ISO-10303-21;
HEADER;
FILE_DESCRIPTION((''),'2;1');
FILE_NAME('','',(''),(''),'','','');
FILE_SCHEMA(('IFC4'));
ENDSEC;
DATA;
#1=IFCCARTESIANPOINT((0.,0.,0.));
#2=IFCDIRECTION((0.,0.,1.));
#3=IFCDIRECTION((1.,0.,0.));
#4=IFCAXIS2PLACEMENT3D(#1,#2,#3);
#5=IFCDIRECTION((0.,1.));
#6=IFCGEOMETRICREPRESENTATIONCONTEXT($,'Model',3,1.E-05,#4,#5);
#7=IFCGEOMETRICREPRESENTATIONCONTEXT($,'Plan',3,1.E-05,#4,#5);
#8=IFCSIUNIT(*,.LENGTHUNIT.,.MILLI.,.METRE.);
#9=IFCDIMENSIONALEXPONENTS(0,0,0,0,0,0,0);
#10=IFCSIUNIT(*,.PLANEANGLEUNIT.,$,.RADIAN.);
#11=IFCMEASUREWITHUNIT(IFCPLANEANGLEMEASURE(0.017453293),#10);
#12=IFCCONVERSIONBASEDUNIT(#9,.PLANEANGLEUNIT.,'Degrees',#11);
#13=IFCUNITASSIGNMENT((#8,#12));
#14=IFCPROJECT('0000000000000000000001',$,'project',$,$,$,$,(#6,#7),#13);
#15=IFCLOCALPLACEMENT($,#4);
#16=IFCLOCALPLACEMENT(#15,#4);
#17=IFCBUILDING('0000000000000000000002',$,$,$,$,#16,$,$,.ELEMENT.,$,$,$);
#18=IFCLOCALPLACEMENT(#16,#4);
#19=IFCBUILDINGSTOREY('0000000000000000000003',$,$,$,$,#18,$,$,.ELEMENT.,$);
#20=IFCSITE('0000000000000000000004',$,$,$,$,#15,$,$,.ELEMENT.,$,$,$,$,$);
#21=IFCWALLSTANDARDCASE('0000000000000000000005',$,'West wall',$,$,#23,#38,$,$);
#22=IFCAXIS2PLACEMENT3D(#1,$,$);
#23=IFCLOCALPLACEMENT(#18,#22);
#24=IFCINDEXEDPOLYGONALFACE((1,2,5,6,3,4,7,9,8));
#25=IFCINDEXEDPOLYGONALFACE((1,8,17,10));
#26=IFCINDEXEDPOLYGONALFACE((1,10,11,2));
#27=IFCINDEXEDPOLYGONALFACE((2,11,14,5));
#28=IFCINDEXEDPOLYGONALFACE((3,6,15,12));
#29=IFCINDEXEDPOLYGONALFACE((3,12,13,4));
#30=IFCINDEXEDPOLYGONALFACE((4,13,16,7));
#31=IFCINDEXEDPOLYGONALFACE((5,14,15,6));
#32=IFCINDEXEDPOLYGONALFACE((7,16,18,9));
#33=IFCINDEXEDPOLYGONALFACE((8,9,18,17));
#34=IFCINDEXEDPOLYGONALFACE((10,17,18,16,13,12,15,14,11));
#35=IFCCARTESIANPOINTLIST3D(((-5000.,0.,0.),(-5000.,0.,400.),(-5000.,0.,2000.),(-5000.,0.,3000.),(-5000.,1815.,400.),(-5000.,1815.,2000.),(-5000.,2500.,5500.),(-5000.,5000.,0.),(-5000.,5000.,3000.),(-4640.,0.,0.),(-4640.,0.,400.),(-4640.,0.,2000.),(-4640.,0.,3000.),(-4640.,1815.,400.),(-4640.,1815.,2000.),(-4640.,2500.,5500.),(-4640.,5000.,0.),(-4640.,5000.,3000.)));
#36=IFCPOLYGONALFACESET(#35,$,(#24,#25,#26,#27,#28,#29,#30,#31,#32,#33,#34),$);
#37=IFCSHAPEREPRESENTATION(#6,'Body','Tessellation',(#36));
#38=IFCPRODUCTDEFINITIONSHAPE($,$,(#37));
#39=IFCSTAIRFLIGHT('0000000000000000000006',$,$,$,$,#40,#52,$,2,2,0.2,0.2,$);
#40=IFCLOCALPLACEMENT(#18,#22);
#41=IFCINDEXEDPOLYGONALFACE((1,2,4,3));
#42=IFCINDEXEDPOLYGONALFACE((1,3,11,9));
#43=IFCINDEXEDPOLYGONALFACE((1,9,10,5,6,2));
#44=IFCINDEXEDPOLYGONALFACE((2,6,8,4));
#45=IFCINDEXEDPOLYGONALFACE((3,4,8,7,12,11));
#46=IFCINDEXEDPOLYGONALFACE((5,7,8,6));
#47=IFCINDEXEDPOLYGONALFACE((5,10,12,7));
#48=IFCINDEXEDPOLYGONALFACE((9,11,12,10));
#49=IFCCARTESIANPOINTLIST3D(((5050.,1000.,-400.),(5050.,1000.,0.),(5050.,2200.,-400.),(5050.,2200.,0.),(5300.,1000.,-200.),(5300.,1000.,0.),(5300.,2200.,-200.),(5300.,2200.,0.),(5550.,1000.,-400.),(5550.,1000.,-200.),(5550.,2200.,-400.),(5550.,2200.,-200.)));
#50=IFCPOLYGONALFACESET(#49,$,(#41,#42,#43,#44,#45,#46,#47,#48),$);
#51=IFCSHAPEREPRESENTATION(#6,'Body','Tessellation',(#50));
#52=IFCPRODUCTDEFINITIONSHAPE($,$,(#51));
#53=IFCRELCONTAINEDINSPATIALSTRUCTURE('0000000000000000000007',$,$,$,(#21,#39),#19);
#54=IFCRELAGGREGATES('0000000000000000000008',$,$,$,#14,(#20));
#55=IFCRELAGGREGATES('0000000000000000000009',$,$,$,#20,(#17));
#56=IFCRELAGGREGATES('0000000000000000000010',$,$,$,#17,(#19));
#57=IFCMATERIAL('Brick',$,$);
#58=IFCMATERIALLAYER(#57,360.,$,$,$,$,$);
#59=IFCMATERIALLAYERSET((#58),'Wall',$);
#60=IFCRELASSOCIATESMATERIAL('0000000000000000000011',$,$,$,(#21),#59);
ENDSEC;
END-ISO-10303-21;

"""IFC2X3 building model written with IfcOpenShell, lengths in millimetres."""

from ifc_helpers import new_model, entity, si_unit, converted_unit, direction, frame, origin_with_axes, place, context, project, spatial, polyline, outline, extrude, clip, halfspace, material, layer, layer_set, layer_usage, element, save


model = new_model("IFC2X3")

# Units and contexts
model_context = context("Model", 3, precision=1e-05, world=origin_with_axes(), true_north=direction((0.0, 1.0)))
plan_context = context("Plan", 3, precision=1e-05, world=origin_with_axes(), true_north=direction((0.0, 1.0)))
ifc_project = project(units=[si_unit("LENGTHUNIT", "METRE", prefix="MILLI"), converted_unit("PLANEANGLEUNIT", "Degrees", entity("IfcPlaneAngleMeasure", 0.017453293), si_unit("PLANEANGLEUNIT", "RADIAN"), dimensions=[0, 0, 0, 0, 0, 0, 0])], contexts=[model_context, plan_context])

# Site, building, storey
site_placement = place(None, origin_with_axes())
site = spatial("IfcSite", under=ifc_project, at=site_placement, CompositionType="ELEMENT")
building_placement = place(site_placement, origin_with_axes())
building = spatial("IfcBuilding", under=site, at=building_placement, CompositionType="ELEMENT")
storey_placement = place(building_placement, origin_with_axes())
storey = spatial("IfcBuildingStorey", under=building, at=storey_placement, CompositionType="ELEMENT")

# Shared definitions
ifc_material = material(Name="Brick")
ifc_layer = layer(ifc_material, 360.0)
ifc_layer_set = layer_set([ifc_layer], Name="Wall")
ifc_layer_usage = layer_usage(ifc_layer_set, "AXIS2", "POSITIVE", -180.0)

# Wall, opening
wall_1_placement = place(storey_placement, frame((-4820.0, 2500.0, 0.0), z_axis=(0.0, 0.0, 1.0), x_axis=(0.0, -1.0, 0.0)))
wall_1 = element("IfcWallStandardCase", 1, at=wall_1_placement, inside=storey, material=ifc_layer_usage, Name="West wall", context=model_context, shape_type="Clipping", body=[
    clip(clip(extrude(outline(polyline([(-2500.0, -180.0), (2500.0, -180.0), (2500.0, 180.0), (-2500.0, 180.0), (-2500.0, -180.0)])), origin_with_axes(), (0.0, 0.0, 1.0), 6000.0), halfspace(frame((-2500.0, 0.0, 3000.0), z_axis=(-1.0, 0.0, 1.0), x_axis=(1.0, 0.0, 0.0)), False)), halfspace(frame((2500.0, 0.0, 3000.0), z_axis=(1.0, 0.0, 1.0), x_axis=(1.0, 0.0, 0.0)), False)),
])
opening_1_placement = place(wall_1_placement, frame((2500.0, 2320.0, 400.0), z_axis=(0.0, 0.0, 1.0), x_axis=(0.0, 1.0, 0.0)))
element("IfcOpeningElement", 2, at=opening_1_placement, cuts=wall_1, context=model_context, shape_type="SweptSolid", body=[
    extrude(outline(polyline([(-3000.0, -1815.0), (3000.0, -1815.0), (3000.0, 1815.0), (-3000.0, 1815.0), (-3000.0, -1815.0)])), origin_with_axes(), (0.0, 0.0, 1.0), 1600.0),
])

# Stair flight
stair_flight_placement = place(storey_placement, frame((5050.0, 1000.0, 0.0), z_axis=(0.0, 1.0, 0.0), x_axis=(1.0, 0.0, 0.0)))
element("IfcStairFlight", 3, at=stair_flight_placement, inside=storey, NumberOfRiser=2, NumberOfTreads=2, RiserHeight=0.2, TreadLength=0.2, context=model_context, shape_type="SweptSolid", body=[
    extrude(outline(polyline([(0.0, 0.0), (250.0, 0.0), (250.0, 200.0), (500.0, 200.0), (500.0, 400.0), (0.0, 400.0), (0.0, 0.0)])), origin_with_axes(), (0.0, 0.0, 1.0), 1200.0),
])

save(model, "model.ifc")
